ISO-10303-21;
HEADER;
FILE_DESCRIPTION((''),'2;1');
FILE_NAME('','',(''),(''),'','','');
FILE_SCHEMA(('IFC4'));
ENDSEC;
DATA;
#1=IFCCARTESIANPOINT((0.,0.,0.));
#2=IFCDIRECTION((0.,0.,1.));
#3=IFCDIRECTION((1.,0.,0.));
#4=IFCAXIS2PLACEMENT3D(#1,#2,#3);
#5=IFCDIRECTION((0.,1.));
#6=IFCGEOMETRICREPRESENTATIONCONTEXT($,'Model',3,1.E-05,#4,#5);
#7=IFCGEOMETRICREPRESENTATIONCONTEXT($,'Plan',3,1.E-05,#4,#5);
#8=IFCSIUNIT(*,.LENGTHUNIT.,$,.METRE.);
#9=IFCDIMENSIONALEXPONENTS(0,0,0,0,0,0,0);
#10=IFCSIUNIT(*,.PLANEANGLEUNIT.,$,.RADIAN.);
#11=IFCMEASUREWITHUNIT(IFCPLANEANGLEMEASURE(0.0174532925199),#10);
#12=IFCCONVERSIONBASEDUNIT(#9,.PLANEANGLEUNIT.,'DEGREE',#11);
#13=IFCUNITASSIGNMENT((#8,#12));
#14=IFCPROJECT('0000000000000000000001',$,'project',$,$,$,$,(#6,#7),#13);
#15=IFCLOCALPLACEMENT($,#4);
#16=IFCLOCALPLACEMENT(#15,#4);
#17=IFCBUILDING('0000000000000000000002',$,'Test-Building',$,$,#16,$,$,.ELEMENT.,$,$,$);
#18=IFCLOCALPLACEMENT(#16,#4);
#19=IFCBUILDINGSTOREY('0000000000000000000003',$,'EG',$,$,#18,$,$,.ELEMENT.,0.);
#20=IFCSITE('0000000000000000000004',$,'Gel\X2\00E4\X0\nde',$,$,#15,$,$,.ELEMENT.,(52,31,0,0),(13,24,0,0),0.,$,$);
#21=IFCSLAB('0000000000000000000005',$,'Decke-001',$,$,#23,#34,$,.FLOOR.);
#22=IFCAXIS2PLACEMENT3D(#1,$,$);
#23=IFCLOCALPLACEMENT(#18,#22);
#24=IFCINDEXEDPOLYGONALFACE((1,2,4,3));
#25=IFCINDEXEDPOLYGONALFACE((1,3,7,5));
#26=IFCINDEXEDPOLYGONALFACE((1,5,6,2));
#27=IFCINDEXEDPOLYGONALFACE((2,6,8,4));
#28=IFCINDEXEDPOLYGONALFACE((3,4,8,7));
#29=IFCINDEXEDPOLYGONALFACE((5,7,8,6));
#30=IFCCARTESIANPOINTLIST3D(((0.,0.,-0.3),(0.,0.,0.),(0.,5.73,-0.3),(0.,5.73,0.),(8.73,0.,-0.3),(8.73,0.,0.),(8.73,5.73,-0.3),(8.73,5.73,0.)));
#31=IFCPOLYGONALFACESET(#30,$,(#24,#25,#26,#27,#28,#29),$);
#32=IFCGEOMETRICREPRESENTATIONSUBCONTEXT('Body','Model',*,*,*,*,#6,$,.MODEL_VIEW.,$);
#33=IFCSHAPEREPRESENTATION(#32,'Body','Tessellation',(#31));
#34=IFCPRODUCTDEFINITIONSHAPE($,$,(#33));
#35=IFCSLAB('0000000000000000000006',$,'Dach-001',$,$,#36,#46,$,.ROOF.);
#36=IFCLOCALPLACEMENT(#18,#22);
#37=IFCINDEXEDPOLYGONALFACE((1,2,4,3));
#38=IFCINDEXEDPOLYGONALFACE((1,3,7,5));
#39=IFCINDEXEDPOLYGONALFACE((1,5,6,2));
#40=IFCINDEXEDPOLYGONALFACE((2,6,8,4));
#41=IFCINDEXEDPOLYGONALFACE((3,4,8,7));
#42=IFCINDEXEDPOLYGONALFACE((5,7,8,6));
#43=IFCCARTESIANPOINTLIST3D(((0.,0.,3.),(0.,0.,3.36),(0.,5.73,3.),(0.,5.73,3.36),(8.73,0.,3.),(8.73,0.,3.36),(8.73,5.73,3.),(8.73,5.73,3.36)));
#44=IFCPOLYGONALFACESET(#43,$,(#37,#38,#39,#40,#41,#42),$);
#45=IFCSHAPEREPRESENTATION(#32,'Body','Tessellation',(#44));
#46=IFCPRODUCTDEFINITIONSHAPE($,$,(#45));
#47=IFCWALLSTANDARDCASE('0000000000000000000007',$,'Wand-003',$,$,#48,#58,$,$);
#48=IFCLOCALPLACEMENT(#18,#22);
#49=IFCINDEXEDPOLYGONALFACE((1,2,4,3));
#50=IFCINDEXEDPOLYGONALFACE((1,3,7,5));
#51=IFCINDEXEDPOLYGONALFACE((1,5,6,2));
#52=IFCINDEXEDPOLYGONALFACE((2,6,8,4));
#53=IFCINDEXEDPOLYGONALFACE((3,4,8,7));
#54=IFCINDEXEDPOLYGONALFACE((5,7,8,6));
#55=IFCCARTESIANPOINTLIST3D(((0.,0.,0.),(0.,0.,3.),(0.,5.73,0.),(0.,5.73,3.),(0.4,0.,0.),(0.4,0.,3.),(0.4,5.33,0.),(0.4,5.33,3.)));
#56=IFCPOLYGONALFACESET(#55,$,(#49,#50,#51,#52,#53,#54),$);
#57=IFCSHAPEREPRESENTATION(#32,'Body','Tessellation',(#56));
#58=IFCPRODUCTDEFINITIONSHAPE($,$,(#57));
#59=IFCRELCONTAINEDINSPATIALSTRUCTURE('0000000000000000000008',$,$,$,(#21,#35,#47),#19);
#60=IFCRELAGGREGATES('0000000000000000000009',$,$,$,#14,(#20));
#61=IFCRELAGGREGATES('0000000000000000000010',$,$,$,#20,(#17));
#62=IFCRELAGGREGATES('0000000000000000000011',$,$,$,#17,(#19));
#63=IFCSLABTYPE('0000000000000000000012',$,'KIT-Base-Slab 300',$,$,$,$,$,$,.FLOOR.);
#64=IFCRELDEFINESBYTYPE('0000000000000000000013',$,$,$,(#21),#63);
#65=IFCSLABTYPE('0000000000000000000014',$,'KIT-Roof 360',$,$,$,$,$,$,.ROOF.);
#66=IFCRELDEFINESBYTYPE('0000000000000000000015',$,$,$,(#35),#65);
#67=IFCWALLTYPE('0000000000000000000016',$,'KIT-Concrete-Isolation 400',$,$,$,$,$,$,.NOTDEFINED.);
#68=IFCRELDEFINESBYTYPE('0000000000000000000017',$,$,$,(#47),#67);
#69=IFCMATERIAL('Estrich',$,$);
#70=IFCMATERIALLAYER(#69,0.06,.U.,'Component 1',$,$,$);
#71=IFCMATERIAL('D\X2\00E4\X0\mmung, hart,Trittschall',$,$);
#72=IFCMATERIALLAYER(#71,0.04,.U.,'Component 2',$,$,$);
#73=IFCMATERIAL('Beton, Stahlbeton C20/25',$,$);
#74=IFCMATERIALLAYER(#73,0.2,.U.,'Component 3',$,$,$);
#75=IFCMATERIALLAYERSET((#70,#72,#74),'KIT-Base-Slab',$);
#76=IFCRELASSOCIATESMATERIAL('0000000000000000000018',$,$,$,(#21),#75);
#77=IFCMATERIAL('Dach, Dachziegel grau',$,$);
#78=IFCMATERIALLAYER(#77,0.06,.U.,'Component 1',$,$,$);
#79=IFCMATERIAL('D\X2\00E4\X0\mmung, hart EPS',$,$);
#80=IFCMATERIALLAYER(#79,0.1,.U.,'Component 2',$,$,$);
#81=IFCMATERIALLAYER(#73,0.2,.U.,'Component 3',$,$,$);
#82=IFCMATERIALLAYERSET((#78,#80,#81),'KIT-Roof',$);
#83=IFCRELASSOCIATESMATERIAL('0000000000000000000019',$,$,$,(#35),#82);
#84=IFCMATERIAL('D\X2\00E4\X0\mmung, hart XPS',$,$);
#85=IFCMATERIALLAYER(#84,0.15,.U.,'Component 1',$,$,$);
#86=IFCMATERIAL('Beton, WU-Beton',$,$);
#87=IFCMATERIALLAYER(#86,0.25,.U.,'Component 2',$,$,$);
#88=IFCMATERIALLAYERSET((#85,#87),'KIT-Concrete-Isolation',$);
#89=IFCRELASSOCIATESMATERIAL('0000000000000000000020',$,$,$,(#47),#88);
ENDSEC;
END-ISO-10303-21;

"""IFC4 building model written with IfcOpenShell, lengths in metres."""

from ifc_helpers import new_model, entity, si_unit, converted_unit, direction, frame, origin_with_axes, place, context, subcontext, project, spatial, polyline, outline, extrude, material, layer, layer_set, layer_usage, type_object, element, save


model = new_model("IFC4")

# Units and contexts
model_context = context("Model", 3, precision=1e-05, world=origin_with_axes(), true_north=direction((0.0, 1.0)))
plan_context = context("Plan", 3, precision=1e-05, world=origin_with_axes(), true_north=direction((0.0, 1.0)))
body_context = subcontext(model_context, "Body", "Model", "MODEL_VIEW")
ifc_project = project(units=[si_unit("LENGTHUNIT", "METRE"), converted_unit("PLANEANGLEUNIT", "DEGREE", entity("IfcPlaneAngleMeasure", 0.0174532925199), si_unit("PLANEANGLEUNIT", "RADIAN"), dimensions=[0, 0, 0, 0, 0, 0, 0])], contexts=[model_context, plan_context])

# Site, building, storey
site_placement = place(None, origin_with_axes())
site = spatial("IfcSite", under=ifc_project, at=site_placement, Name="Gelände", CompositionType="ELEMENT", RefLatitude=(52, 31, 0, 0), RefLongitude=(13, 24, 0, 0), RefElevation=0.0)
building_placement = place(site_placement, origin_with_axes())
building = spatial("IfcBuilding", under=site, at=building_placement, Name="Test-Building", CompositionType="ELEMENT")
storey_placement = place(building_placement, origin_with_axes())
storey = spatial("IfcBuildingStorey", under=building, at=storey_placement, Name="EG", CompositionType="ELEMENT", Elevation=0.0)

# Slabs
ifc_material_1 = material(Name="Estrich")
ifc_layer_1 = layer(ifc_material_1, 0.06, ventilated="UNKNOWN", Name="Component 1")
ifc_material_2 = material(Name="Dämmung, hart,Trittschall")
ifc_layer_2 = layer(ifc_material_2, 0.04, ventilated="UNKNOWN", Name="Component 2")
ifc_material_3 = material(Name="Beton, Stahlbeton C20/25")
ifc_layer_3 = layer(ifc_material_3, 0.2, ventilated="UNKNOWN", Name="Component 3")
ifc_layer_set_1 = layer_set([ifc_layer_1, ifc_layer_2, ifc_layer_3], Name="KIT-Base-Slab")
ifc_layer_usage_1 = layer_usage(ifc_layer_set_1, "AXIS3", "NEGATIVE", 0.3)
slab_type_1 = type_object("IfcSlabType", Name="KIT-Base-Slab 300", PredefinedType="FLOOR")
slab_1_placement = place(storey_placement, origin_with_axes())
element("IfcSlab", 1, at=slab_1_placement, inside=storey, type_object=slab_type_1, material=ifc_layer_usage_1, Name="Decke-001", PredefinedType="FLOOR", context=body_context, shape_type="SweptSolid", body=[
    extrude(outline(polyline([(0.0, 0.0), (8.73, 0.0), (8.73, 5.73), (0.0, 5.73), (0.0, 0.0)])), frame((0.0, 0.0, -0.3), z_axis=(0.0, 0.0, 1.0), x_axis=(1.0, 0.0, 0.0)), (0.0, 0.0, 1.0), 0.3),
])
ifc_material_4 = material(Name="Dach, Dachziegel grau")
ifc_layer_4 = layer(ifc_material_4, 0.06, ventilated="UNKNOWN", Name="Component 1")
ifc_material_5 = material(Name="Dämmung, hart EPS")
ifc_layer_5 = layer(ifc_material_5, 0.1, ventilated="UNKNOWN", Name="Component 2")
ifc_layer_6 = layer(ifc_material_3, 0.2, ventilated="UNKNOWN", Name="Component 3")
ifc_layer_set_2 = layer_set([ifc_layer_4, ifc_layer_5, ifc_layer_6], Name="KIT-Roof")
ifc_layer_usage_2 = layer_usage(ifc_layer_set_2, "AXIS3", "NEGATIVE", 0.36)
slab_type_2 = type_object("IfcSlabType", Name="KIT-Roof 360", PredefinedType="ROOF")
slab_2_placement = place(storey_placement, frame((0.0, 0.0, 3.0), z_axis=(0.0, 0.0, 1.0), x_axis=(1.0, 0.0, 0.0)))
element("IfcSlab", 2, at=slab_2_placement, inside=storey, type_object=slab_type_2, material=ifc_layer_usage_2, Name="Dach-001", PredefinedType="ROOF", context=body_context, shape_type="SweptSolid", body=[
    extrude(outline(polyline([(0.0, 0.0), (8.73, 0.0), (8.73, 5.73), (0.0, 5.73), (0.0, 0.0)])), origin_with_axes(), (0.0, 0.0, 1.0), 0.36),
])

# Wall
ifc_material_6 = material(Name="Dämmung, hart XPS")
ifc_layer_7 = layer(ifc_material_6, 0.15, ventilated="UNKNOWN", Name="Component 1")
ifc_material_7 = material(Name="Beton, WU-Beton")
ifc_layer_8 = layer(ifc_material_7, 0.25, ventilated="UNKNOWN", Name="Component 2")
ifc_layer_set_3 = layer_set([ifc_layer_7, ifc_layer_8], Name="KIT-Concrete-Isolation")
ifc_layer_usage_3 = layer_usage(ifc_layer_set_3, "AXIS2", "NEGATIVE", 0.0)
wall_type = type_object("IfcWallType", Name="KIT-Concrete-Isolation 400", PredefinedType="NOTDEFINED")
wall_placement = place(storey_placement, frame((0.0, 0.0, 0.0), z_axis=(0.0, 0.0, 1.0), x_axis=(0.0, 1.0, 0.0)))
element("IfcWallStandardCase", 3, at=wall_placement, inside=storey, type_object=wall_type, material=ifc_layer_usage_3, Name="Wand-003", context=body_context, shape_type="SweptSolid", body=[
    extrude(outline(polyline([(0.0, -0.4), (5.33, -0.4), (5.73, 0.0), (0.0, 0.0), (0.0, -0.4)])), origin_with_axes(), (0.0, 0.0, 1.0), 3.0),
])

save(model, "model.ifc")
